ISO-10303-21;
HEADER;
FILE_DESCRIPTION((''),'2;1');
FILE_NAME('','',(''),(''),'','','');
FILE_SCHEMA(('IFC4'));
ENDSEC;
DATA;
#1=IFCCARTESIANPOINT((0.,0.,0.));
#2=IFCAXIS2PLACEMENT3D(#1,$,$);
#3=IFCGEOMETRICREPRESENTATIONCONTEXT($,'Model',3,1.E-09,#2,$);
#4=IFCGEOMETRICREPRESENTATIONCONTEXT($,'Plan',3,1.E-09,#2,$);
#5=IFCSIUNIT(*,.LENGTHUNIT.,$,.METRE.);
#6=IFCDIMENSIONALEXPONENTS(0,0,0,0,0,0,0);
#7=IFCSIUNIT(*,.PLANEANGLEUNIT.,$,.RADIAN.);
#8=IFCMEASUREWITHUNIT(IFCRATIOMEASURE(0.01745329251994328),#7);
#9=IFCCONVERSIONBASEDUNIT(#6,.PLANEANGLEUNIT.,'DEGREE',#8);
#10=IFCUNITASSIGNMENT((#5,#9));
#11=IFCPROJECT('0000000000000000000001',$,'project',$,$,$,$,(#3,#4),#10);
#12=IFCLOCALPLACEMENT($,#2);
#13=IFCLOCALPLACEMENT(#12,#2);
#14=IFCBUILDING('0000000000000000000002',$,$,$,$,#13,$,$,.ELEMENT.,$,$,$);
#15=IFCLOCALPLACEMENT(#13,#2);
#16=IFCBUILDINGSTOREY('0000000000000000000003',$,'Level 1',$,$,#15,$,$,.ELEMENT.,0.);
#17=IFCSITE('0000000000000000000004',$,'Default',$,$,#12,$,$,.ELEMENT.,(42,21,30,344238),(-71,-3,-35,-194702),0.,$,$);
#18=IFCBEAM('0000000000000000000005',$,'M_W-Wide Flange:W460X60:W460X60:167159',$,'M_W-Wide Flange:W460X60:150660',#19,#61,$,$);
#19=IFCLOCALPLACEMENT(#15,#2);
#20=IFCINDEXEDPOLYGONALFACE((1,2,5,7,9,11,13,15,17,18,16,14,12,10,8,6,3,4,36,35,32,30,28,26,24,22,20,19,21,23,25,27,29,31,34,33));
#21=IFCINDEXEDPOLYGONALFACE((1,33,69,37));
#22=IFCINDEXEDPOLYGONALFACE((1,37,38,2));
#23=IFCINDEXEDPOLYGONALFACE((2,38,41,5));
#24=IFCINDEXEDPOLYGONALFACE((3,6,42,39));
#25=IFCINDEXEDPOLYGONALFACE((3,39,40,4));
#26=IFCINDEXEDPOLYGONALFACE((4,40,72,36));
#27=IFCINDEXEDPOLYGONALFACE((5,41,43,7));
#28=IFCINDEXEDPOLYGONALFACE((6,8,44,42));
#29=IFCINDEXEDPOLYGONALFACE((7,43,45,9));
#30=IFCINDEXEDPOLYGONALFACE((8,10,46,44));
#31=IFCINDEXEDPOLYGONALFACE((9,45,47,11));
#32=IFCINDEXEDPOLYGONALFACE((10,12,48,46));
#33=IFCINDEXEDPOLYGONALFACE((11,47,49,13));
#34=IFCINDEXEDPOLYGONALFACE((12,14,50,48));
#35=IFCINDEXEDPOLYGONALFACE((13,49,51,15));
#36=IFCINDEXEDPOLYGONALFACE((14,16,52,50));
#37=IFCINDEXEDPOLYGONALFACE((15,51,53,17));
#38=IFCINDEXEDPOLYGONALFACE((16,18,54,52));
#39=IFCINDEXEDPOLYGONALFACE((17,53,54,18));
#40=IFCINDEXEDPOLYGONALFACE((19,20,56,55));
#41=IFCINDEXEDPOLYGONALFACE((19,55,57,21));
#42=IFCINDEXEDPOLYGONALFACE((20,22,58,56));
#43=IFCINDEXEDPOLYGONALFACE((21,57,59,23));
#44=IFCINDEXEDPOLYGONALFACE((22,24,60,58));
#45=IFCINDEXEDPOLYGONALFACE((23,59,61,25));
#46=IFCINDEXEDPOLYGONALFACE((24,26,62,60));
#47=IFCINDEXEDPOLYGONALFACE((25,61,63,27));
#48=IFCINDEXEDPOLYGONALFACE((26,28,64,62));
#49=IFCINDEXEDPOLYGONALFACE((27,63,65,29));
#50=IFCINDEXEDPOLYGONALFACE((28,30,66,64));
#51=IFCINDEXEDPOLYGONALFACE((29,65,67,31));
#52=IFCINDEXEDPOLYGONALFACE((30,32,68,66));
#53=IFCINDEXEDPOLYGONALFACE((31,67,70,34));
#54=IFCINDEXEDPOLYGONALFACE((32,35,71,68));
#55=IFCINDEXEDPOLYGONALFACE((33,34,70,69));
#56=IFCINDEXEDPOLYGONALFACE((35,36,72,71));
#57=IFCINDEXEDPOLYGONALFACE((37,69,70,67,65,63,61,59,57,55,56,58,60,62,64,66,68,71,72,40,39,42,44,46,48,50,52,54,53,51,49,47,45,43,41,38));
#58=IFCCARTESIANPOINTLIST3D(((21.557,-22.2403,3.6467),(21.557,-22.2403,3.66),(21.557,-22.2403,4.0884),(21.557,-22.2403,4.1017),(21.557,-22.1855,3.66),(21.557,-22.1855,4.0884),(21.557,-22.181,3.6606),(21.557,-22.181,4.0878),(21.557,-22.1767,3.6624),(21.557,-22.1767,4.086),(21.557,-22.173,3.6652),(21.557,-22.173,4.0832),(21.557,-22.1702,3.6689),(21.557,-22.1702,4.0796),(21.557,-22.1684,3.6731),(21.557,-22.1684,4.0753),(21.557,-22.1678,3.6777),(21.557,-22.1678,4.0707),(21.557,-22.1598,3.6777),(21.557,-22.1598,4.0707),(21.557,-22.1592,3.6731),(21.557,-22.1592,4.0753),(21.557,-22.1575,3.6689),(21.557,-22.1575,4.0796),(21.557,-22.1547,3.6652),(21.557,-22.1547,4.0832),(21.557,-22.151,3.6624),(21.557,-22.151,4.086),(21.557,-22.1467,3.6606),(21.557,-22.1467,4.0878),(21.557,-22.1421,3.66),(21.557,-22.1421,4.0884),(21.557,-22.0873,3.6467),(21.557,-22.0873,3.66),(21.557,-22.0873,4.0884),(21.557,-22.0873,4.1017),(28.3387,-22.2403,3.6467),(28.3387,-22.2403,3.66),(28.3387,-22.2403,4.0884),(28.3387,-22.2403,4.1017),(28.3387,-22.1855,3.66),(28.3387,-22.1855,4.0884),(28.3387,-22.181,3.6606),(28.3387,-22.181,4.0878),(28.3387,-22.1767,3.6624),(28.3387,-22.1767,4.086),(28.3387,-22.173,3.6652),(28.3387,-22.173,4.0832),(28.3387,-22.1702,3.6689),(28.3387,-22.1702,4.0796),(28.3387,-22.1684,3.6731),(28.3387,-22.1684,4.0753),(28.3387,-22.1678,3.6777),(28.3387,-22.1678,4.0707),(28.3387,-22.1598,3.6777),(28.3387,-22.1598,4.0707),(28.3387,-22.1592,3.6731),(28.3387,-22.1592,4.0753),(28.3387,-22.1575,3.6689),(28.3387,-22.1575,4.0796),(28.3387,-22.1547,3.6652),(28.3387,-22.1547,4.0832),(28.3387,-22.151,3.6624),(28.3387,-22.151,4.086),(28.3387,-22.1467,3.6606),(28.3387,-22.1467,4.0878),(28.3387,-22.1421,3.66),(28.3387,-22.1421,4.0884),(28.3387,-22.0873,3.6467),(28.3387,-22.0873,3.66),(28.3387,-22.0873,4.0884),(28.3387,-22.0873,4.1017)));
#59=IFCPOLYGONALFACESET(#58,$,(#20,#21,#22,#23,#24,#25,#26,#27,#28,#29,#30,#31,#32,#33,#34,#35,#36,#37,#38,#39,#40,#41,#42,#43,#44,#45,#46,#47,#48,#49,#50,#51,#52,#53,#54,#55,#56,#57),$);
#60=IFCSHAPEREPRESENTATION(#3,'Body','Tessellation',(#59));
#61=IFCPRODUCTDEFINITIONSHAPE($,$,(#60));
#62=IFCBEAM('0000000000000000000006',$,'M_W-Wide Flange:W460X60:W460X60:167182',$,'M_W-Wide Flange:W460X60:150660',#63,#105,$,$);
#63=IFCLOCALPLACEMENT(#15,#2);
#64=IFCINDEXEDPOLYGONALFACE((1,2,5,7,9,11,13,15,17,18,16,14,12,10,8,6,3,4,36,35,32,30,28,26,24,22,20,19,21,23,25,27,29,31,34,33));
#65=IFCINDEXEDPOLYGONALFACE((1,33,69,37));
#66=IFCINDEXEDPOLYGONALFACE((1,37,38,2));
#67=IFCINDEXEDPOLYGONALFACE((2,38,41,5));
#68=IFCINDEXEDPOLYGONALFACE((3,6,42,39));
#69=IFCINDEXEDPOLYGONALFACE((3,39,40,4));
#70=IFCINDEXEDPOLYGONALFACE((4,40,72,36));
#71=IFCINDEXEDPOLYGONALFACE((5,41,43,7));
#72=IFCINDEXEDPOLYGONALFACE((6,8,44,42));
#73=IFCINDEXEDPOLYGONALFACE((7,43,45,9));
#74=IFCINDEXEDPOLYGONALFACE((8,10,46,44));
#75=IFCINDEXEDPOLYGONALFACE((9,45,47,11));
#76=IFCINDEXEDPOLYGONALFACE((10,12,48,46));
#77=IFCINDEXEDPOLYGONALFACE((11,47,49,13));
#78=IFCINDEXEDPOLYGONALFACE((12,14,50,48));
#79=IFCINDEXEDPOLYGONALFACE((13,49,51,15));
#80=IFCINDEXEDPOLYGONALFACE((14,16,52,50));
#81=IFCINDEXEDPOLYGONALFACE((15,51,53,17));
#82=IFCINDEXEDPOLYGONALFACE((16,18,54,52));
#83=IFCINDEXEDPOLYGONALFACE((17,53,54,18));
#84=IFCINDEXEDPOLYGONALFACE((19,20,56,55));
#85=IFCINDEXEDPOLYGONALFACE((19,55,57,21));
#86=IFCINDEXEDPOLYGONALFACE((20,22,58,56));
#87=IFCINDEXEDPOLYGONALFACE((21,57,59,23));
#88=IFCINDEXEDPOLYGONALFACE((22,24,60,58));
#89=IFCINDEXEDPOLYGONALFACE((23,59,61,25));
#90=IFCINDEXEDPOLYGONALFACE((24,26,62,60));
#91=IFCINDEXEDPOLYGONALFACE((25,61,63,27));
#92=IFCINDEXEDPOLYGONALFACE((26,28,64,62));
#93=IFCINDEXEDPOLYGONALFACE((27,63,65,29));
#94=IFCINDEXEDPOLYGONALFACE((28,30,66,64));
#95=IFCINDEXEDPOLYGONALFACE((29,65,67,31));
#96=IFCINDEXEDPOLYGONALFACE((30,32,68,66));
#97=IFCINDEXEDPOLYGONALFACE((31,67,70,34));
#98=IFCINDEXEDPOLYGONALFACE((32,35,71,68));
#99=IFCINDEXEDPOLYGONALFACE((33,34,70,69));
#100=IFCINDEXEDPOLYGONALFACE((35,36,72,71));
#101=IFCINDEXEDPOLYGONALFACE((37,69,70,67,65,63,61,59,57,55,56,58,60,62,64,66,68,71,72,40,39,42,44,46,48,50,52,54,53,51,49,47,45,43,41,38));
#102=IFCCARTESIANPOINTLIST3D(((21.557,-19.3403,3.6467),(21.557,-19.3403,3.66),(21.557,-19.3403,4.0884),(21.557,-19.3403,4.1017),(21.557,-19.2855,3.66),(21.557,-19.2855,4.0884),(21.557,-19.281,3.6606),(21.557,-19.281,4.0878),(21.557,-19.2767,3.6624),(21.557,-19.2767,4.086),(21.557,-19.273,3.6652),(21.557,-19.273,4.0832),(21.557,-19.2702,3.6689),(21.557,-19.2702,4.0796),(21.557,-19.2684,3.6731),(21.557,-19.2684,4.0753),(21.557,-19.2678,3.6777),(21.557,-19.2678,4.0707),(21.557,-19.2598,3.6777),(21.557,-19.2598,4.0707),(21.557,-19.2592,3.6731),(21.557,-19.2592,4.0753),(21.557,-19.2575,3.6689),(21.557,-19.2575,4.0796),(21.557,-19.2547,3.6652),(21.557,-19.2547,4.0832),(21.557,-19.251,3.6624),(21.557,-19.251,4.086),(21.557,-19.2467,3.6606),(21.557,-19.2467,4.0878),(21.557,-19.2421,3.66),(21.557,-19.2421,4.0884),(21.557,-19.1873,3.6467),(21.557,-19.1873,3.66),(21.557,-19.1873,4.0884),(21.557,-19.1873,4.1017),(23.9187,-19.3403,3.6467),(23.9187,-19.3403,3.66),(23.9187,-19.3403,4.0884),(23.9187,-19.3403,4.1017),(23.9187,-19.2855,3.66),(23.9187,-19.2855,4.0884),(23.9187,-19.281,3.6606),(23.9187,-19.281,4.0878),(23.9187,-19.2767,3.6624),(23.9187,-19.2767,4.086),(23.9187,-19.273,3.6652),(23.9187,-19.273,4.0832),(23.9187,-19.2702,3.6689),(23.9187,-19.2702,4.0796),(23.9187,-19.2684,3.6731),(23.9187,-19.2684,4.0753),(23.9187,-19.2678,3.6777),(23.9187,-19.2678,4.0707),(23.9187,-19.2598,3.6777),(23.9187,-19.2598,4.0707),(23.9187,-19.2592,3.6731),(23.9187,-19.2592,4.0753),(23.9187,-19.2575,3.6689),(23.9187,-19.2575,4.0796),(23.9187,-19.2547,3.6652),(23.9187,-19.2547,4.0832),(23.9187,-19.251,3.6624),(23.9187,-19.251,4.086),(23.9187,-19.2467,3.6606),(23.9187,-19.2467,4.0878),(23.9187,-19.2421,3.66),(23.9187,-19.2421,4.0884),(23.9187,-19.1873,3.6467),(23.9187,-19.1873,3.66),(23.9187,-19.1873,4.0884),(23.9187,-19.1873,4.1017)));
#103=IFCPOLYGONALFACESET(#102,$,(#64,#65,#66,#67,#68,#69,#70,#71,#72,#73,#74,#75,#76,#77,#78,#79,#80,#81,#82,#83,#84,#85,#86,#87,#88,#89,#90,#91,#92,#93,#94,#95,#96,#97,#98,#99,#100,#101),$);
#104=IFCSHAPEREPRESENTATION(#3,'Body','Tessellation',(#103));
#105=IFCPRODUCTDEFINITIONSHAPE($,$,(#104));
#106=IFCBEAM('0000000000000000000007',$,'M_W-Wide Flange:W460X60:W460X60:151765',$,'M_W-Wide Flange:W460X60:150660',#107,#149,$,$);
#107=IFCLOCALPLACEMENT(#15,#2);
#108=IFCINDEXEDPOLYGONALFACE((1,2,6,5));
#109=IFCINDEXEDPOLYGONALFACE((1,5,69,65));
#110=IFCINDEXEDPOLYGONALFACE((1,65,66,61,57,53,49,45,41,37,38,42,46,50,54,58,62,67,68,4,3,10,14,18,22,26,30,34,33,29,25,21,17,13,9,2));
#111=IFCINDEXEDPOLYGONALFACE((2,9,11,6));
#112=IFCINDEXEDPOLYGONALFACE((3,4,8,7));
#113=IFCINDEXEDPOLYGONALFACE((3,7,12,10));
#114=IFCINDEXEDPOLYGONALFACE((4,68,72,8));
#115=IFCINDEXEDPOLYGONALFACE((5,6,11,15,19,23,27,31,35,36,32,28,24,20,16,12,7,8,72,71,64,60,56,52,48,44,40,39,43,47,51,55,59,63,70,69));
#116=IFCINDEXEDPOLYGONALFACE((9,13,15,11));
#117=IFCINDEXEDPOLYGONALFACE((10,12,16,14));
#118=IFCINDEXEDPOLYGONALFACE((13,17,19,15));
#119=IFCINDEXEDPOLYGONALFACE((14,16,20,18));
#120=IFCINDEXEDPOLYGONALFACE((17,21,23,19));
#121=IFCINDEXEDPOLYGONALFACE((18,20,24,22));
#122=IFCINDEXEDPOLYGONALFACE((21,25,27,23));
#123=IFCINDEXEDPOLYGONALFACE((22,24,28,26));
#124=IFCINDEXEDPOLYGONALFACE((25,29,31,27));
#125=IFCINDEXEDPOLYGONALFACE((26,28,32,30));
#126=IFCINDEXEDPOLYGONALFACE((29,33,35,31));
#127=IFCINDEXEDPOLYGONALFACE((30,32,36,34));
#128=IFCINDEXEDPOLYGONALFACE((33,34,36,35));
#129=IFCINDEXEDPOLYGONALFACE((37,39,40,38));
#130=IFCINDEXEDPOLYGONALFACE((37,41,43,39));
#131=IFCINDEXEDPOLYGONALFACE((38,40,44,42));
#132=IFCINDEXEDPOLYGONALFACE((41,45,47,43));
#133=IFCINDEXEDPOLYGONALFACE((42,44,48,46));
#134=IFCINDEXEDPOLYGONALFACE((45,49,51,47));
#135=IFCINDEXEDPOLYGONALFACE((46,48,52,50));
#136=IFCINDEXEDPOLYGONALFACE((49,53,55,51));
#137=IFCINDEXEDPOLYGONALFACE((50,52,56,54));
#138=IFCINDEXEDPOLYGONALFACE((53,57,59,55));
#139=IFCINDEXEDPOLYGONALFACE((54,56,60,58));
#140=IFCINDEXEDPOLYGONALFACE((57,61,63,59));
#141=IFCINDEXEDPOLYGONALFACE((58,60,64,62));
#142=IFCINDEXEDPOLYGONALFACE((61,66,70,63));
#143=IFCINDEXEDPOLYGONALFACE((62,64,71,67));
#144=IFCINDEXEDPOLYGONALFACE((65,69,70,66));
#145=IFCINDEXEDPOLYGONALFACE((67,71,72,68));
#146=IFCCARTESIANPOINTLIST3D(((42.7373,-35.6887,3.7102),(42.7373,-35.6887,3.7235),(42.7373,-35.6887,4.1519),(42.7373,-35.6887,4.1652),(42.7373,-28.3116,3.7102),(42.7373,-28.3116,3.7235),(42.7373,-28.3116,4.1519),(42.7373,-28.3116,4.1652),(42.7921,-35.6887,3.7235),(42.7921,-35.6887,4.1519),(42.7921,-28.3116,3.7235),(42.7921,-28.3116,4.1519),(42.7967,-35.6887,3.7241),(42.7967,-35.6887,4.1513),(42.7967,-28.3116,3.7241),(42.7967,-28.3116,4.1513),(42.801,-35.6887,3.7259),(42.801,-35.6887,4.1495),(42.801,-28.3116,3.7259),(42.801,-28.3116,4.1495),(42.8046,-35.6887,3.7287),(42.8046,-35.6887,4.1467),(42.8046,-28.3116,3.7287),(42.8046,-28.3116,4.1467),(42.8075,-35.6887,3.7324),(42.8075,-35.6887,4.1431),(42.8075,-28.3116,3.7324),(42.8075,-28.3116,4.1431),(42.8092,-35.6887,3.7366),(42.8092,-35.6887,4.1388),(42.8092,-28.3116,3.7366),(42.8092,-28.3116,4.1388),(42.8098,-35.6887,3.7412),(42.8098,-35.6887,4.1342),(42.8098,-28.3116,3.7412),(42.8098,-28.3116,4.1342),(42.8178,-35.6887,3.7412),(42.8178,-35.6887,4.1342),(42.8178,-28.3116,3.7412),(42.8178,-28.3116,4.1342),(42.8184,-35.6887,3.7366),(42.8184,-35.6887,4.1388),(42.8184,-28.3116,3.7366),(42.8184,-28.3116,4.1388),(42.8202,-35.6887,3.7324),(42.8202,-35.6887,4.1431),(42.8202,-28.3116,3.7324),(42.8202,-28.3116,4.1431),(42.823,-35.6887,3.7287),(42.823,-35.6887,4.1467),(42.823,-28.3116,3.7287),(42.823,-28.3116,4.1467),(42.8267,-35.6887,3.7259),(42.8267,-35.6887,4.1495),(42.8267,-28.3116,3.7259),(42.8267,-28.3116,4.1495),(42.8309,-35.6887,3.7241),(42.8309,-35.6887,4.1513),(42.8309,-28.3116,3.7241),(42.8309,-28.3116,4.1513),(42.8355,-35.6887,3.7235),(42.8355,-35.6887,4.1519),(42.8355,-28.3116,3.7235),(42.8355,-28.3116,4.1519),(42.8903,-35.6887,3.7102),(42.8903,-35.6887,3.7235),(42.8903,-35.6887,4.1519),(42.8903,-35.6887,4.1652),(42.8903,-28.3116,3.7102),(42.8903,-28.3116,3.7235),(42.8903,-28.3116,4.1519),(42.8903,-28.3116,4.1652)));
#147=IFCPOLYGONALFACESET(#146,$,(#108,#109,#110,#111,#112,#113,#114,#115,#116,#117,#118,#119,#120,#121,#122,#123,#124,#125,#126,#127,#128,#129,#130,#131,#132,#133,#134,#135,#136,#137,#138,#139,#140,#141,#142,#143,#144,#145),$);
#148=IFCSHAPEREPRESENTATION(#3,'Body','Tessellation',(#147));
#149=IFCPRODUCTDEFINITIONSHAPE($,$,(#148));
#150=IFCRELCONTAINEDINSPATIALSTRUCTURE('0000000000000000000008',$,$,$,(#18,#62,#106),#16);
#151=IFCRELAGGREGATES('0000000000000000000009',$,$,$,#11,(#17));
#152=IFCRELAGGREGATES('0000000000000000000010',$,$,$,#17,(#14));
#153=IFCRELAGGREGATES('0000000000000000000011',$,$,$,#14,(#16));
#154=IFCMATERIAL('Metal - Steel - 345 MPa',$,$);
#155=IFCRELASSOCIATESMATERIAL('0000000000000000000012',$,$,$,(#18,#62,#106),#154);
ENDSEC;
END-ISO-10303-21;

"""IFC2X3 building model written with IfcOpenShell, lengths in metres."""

from ifc_helpers import new_model, entity, si_unit, converted_unit, frame, frame_2d, origin, place, context, project, spatial, polyline, circle_curve, parameter, trimmed, segment, composite_curve, outline, extrude, material, element, save


model = new_model("IFC2X3")

# Units and contexts
model_context = context("Model", 3, precision=1e-09, world=origin())
plan_context = context("Plan", 3, precision=1e-09, world=origin())
ifc_project = project(units=[si_unit("LENGTHUNIT", "METRE"), converted_unit("PLANEANGLEUNIT", "DEGREE", entity("IfcRatioMeasure", 0.01745329251994328), si_unit("PLANEANGLEUNIT", "RADIAN"), dimensions=[0, 0, 0, 0, 0, 0, 0])], contexts=[model_context, plan_context])

# Site, building, storey
site_placement = place(None, origin())
site = spatial("IfcSite", under=ifc_project, at=site_placement, Name="Default", CompositionType="ELEMENT", RefLatitude=(42, 21, 30, 344238), RefLongitude=(-71, -3, -35, -194702), RefElevation=0.0)
building_placement = place(site_placement, origin())
building = spatial("IfcBuilding", under=site, at=building_placement, CompositionType="ELEMENT")
storey_placement = place(building_placement, origin())
storey = spatial("IfcBuildingStorey", under=building, at=storey_placement, Name="Level 1", CompositionType="ELEMENT", Elevation=0.0)

# Beams
ifc_material = material(Name="Metal - Steel - 345 MPa")
beam_1_placement = place(storey_placement, frame((28.4279, -22.1638, 4.2672), z_axis=(0.0, 0.0, 1.0), x_axis=(0.0, 1.0, 0.0)))
element("IfcBeam", 1, at=beam_1_placement, inside=storey, material=ifc_material, Name="M_W-Wide Flange:W460X60:W460X60:167159", ObjectType="M_W-Wide Flange:W460X60:150660", context=model_context, shape_type="SweptSolid", body=[
    extrude(outline(composite_curve([segment(polyline([(0.2142, -0.0765), (0.2275, -0.0765)]), True, "CONTINUOUS"), segment(polyline([(0.2275, -0.0765), (0.2275, 0.0765)]), True, "CONTINUOUS"), segment(polyline([(0.2275, 0.0765), (0.2142, 0.0765)]), True, "CONTINUOUS"), segment(polyline([(0.2142, 0.0765), (0.2142, 0.0217)]), True, "CONTINUOUS"), segment(trimmed(circle_curve(frame_2d((0.1965, 0.0217), x_axis=(1.0, 0.0)), 0.0177), [parameter(270.0)], [parameter(360.0)], True, "PARAMETER"), False, "CONTINUOUS"), segment(polyline([(0.1965, 0.004), (-0.1965, 0.004)]), True, "CONTINUOUS"), segment(trimmed(circle_curve(frame_2d((-0.1965, 0.0217), x_axis=(0.0, -1.0)), 0.0177), [parameter(270.0)], [parameter(360.0)], True, "PARAMETER"), False, "CONTINUOUS"), segment(polyline([(-0.2142, 0.0217), (-0.2142, 0.0765)]), True, "CONTINUOUS"), segment(polyline([(-0.2142, 0.0765), (-0.2275, 0.0765)]), True, "CONTINUOUS"), segment(polyline([(-0.2275, 0.0765), (-0.2275, -0.0765)]), True, "CONTINUOUS"), segment(polyline([(-0.2275, -0.0765), (-0.2142, -0.0765)]), True, "CONTINUOUS"), segment(polyline([(-0.2142, -0.0765), (-0.2142, -0.0217)]), True, "CONTINUOUS"), segment(trimmed(circle_curve(frame_2d((-0.1965, -0.0217), x_axis=(-1.0, 0.0)), 0.0177), [parameter(270.0)], [parameter(360.0)], True, "PARAMETER"), False, "CONTINUOUS"), segment(polyline([(-0.1965, -0.004), (0.1965, -0.004)]), True, "CONTINUOUS"), segment(trimmed(circle_curve(frame_2d((0.1965, -0.0217), x_axis=(0.0, 1.0)), 0.0177), [parameter(270.0)], [parameter(0.0)], True, "PARAMETER"), False, "CONTINUOUS"), segment(polyline([(0.2142, -0.0217), (0.2142, -0.0765)]), True, "CONTINUOUS")], self_intersect=False)), frame((0.0, 6.8709, -0.393), z_axis=(0.0, -1.0, 0.0), x_axis=(0.0, 0.0, -1.0)), (0.0, 0.0, 1.0), 6.7817),
])
beam_2_placement = place(storey_placement, frame((28.4279, -19.2638, 4.2672), z_axis=(0.0, 0.0, 1.0), x_axis=(0.0, 1.0, 0.0)))
element("IfcBeam", 2, at=beam_2_placement, inside=storey, material=ifc_material, Name="M_W-Wide Flange:W460X60:W460X60:167182", ObjectType="M_W-Wide Flange:W460X60:150660", context=model_context, shape_type="SweptSolid", body=[
    extrude(outline(composite_curve([segment(polyline([(0.2142, -0.0765), (0.2275, -0.0765)]), True, "CONTINUOUS"), segment(polyline([(0.2275, -0.0765), (0.2275, 0.0765)]), True, "CONTINUOUS"), segment(polyline([(0.2275, 0.0765), (0.2142, 0.0765)]), True, "CONTINUOUS"), segment(polyline([(0.2142, 0.0765), (0.2142, 0.0217)]), True, "CONTINUOUS"), segment(trimmed(circle_curve(frame_2d((0.1965, 0.0217), x_axis=(1.0, 0.0)), 0.0177), [parameter(270.0)], [parameter(360.0)], True, "PARAMETER"), False, "CONTINUOUS"), segment(polyline([(0.1965, 0.004), (-0.1965, 0.004)]), True, "CONTINUOUS"), segment(trimmed(circle_curve(frame_2d((-0.1965, 0.0217), x_axis=(0.0, -1.0)), 0.0177), [parameter(270.0)], [parameter(360.0)], True, "PARAMETER"), False, "CONTINUOUS"), segment(polyline([(-0.2142, 0.0217), (-0.2142, 0.0765)]), True, "CONTINUOUS"), segment(polyline([(-0.2142, 0.0765), (-0.2275, 0.0765)]), True, "CONTINUOUS"), segment(polyline([(-0.2275, 0.0765), (-0.2275, -0.0765)]), True, "CONTINUOUS"), segment(polyline([(-0.2275, -0.0765), (-0.2142, -0.0765)]), True, "CONTINUOUS"), segment(polyline([(-0.2142, -0.0765), (-0.2142, -0.0217)]), True, "CONTINUOUS"), segment(trimmed(circle_curve(frame_2d((-0.1965, -0.0217), x_axis=(-1.0, 0.0)), 0.0177), [parameter(270.0)], [parameter(360.0)], True, "PARAMETER"), False, "CONTINUOUS"), segment(polyline([(-0.1965, -0.004), (0.1965, -0.004)]), True, "CONTINUOUS"), segment(trimmed(circle_curve(frame_2d((0.1965, -0.0217), x_axis=(0.0, 1.0)), 0.0177), [parameter(270.0)], [parameter(0.0)], True, "PARAMETER"), False, "CONTINUOUS"), segment(polyline([(0.2142, -0.0217), (0.2142, -0.0765)]), True, "CONTINUOUS")], self_intersect=False)), frame((0.0, 6.8709, -0.393), z_axis=(0.0, -1.0, 0.0), x_axis=(0.0, 0.0, -1.0)), (0.0, 0.0, 1.0), 2.3617),
])
beam_3_placement = place(storey_placement, frame((42.8138, -28.1704, 4.2672), z_axis=(0.0, 0.0, 1.0), x_axis=(-1.0, 0.0, 0.0)))
element("IfcBeam", 3, at=beam_3_placement, inside=storey, material=ifc_material, Name="M_W-Wide Flange:W460X60:W460X60:151765", ObjectType="M_W-Wide Flange:W460X60:150660", context=model_context, shape_type="SweptSolid", body=[
    extrude(outline(composite_curve([segment(polyline([(0.2142, -0.0765), (0.2275, -0.0765)]), True, "CONTINUOUS"), segment(polyline([(0.2275, -0.0765), (0.2275, 0.0765)]), True, "CONTINUOUS"), segment(polyline([(0.2275, 0.0765), (0.2142, 0.0765)]), True, "CONTINUOUS"), segment(polyline([(0.2142, 0.0765), (0.2142, 0.0217)]), True, "CONTINUOUS"), segment(trimmed(circle_curve(frame_2d((0.1965, 0.0217), x_axis=(1.0, 0.0)), 0.0177), [parameter(270.0)], [parameter(360.0)], True, "PARAMETER"), False, "CONTINUOUS"), segment(polyline([(0.1965, 0.004), (-0.1965, 0.004)]), True, "CONTINUOUS"), segment(trimmed(circle_curve(frame_2d((-0.1965, 0.0217), x_axis=(0.0, -1.0)), 0.0177), [parameter(270.0)], [parameter(360.0)], True, "PARAMETER"), False, "CONTINUOUS"), segment(polyline([(-0.2142, 0.0217), (-0.2142, 0.0765)]), True, "CONTINUOUS"), segment(polyline([(-0.2142, 0.0765), (-0.2275, 0.0765)]), True, "CONTINUOUS"), segment(polyline([(-0.2275, 0.0765), (-0.2275, -0.0765)]), True, "CONTINUOUS"), segment(polyline([(-0.2275, -0.0765), (-0.2142, -0.0765)]), True, "CONTINUOUS"), segment(polyline([(-0.2142, -0.0765), (-0.2142, -0.0217)]), True, "CONTINUOUS"), segment(trimmed(circle_curve(frame_2d((-0.1965, -0.0217), x_axis=(-1.0, 0.0)), 0.0177), [parameter(270.0)], [parameter(360.0)], True, "PARAMETER"), False, "CONTINUOUS"), segment(polyline([(-0.1965, -0.004), (0.1965, -0.004)]), True, "CONTINUOUS"), segment(trimmed(circle_curve(frame_2d((0.1965, -0.0217), x_axis=(0.0, 1.0)), 0.0177), [parameter(270.0)], [parameter(0.0)], True, "PARAMETER"), False, "CONTINUOUS"), segment(polyline([(0.2142, -0.0217), (0.2142, -0.0765)]), True, "CONTINUOUS")], self_intersect=False)), frame((0.0, 7.5183, -0.3295), z_axis=(0.0, -1.0, 0.0), x_axis=(0.0, 0.0, -1.0)), (0.0, 0.0, 1.0), 7.3771),
])

save(model, "model.ifc")
